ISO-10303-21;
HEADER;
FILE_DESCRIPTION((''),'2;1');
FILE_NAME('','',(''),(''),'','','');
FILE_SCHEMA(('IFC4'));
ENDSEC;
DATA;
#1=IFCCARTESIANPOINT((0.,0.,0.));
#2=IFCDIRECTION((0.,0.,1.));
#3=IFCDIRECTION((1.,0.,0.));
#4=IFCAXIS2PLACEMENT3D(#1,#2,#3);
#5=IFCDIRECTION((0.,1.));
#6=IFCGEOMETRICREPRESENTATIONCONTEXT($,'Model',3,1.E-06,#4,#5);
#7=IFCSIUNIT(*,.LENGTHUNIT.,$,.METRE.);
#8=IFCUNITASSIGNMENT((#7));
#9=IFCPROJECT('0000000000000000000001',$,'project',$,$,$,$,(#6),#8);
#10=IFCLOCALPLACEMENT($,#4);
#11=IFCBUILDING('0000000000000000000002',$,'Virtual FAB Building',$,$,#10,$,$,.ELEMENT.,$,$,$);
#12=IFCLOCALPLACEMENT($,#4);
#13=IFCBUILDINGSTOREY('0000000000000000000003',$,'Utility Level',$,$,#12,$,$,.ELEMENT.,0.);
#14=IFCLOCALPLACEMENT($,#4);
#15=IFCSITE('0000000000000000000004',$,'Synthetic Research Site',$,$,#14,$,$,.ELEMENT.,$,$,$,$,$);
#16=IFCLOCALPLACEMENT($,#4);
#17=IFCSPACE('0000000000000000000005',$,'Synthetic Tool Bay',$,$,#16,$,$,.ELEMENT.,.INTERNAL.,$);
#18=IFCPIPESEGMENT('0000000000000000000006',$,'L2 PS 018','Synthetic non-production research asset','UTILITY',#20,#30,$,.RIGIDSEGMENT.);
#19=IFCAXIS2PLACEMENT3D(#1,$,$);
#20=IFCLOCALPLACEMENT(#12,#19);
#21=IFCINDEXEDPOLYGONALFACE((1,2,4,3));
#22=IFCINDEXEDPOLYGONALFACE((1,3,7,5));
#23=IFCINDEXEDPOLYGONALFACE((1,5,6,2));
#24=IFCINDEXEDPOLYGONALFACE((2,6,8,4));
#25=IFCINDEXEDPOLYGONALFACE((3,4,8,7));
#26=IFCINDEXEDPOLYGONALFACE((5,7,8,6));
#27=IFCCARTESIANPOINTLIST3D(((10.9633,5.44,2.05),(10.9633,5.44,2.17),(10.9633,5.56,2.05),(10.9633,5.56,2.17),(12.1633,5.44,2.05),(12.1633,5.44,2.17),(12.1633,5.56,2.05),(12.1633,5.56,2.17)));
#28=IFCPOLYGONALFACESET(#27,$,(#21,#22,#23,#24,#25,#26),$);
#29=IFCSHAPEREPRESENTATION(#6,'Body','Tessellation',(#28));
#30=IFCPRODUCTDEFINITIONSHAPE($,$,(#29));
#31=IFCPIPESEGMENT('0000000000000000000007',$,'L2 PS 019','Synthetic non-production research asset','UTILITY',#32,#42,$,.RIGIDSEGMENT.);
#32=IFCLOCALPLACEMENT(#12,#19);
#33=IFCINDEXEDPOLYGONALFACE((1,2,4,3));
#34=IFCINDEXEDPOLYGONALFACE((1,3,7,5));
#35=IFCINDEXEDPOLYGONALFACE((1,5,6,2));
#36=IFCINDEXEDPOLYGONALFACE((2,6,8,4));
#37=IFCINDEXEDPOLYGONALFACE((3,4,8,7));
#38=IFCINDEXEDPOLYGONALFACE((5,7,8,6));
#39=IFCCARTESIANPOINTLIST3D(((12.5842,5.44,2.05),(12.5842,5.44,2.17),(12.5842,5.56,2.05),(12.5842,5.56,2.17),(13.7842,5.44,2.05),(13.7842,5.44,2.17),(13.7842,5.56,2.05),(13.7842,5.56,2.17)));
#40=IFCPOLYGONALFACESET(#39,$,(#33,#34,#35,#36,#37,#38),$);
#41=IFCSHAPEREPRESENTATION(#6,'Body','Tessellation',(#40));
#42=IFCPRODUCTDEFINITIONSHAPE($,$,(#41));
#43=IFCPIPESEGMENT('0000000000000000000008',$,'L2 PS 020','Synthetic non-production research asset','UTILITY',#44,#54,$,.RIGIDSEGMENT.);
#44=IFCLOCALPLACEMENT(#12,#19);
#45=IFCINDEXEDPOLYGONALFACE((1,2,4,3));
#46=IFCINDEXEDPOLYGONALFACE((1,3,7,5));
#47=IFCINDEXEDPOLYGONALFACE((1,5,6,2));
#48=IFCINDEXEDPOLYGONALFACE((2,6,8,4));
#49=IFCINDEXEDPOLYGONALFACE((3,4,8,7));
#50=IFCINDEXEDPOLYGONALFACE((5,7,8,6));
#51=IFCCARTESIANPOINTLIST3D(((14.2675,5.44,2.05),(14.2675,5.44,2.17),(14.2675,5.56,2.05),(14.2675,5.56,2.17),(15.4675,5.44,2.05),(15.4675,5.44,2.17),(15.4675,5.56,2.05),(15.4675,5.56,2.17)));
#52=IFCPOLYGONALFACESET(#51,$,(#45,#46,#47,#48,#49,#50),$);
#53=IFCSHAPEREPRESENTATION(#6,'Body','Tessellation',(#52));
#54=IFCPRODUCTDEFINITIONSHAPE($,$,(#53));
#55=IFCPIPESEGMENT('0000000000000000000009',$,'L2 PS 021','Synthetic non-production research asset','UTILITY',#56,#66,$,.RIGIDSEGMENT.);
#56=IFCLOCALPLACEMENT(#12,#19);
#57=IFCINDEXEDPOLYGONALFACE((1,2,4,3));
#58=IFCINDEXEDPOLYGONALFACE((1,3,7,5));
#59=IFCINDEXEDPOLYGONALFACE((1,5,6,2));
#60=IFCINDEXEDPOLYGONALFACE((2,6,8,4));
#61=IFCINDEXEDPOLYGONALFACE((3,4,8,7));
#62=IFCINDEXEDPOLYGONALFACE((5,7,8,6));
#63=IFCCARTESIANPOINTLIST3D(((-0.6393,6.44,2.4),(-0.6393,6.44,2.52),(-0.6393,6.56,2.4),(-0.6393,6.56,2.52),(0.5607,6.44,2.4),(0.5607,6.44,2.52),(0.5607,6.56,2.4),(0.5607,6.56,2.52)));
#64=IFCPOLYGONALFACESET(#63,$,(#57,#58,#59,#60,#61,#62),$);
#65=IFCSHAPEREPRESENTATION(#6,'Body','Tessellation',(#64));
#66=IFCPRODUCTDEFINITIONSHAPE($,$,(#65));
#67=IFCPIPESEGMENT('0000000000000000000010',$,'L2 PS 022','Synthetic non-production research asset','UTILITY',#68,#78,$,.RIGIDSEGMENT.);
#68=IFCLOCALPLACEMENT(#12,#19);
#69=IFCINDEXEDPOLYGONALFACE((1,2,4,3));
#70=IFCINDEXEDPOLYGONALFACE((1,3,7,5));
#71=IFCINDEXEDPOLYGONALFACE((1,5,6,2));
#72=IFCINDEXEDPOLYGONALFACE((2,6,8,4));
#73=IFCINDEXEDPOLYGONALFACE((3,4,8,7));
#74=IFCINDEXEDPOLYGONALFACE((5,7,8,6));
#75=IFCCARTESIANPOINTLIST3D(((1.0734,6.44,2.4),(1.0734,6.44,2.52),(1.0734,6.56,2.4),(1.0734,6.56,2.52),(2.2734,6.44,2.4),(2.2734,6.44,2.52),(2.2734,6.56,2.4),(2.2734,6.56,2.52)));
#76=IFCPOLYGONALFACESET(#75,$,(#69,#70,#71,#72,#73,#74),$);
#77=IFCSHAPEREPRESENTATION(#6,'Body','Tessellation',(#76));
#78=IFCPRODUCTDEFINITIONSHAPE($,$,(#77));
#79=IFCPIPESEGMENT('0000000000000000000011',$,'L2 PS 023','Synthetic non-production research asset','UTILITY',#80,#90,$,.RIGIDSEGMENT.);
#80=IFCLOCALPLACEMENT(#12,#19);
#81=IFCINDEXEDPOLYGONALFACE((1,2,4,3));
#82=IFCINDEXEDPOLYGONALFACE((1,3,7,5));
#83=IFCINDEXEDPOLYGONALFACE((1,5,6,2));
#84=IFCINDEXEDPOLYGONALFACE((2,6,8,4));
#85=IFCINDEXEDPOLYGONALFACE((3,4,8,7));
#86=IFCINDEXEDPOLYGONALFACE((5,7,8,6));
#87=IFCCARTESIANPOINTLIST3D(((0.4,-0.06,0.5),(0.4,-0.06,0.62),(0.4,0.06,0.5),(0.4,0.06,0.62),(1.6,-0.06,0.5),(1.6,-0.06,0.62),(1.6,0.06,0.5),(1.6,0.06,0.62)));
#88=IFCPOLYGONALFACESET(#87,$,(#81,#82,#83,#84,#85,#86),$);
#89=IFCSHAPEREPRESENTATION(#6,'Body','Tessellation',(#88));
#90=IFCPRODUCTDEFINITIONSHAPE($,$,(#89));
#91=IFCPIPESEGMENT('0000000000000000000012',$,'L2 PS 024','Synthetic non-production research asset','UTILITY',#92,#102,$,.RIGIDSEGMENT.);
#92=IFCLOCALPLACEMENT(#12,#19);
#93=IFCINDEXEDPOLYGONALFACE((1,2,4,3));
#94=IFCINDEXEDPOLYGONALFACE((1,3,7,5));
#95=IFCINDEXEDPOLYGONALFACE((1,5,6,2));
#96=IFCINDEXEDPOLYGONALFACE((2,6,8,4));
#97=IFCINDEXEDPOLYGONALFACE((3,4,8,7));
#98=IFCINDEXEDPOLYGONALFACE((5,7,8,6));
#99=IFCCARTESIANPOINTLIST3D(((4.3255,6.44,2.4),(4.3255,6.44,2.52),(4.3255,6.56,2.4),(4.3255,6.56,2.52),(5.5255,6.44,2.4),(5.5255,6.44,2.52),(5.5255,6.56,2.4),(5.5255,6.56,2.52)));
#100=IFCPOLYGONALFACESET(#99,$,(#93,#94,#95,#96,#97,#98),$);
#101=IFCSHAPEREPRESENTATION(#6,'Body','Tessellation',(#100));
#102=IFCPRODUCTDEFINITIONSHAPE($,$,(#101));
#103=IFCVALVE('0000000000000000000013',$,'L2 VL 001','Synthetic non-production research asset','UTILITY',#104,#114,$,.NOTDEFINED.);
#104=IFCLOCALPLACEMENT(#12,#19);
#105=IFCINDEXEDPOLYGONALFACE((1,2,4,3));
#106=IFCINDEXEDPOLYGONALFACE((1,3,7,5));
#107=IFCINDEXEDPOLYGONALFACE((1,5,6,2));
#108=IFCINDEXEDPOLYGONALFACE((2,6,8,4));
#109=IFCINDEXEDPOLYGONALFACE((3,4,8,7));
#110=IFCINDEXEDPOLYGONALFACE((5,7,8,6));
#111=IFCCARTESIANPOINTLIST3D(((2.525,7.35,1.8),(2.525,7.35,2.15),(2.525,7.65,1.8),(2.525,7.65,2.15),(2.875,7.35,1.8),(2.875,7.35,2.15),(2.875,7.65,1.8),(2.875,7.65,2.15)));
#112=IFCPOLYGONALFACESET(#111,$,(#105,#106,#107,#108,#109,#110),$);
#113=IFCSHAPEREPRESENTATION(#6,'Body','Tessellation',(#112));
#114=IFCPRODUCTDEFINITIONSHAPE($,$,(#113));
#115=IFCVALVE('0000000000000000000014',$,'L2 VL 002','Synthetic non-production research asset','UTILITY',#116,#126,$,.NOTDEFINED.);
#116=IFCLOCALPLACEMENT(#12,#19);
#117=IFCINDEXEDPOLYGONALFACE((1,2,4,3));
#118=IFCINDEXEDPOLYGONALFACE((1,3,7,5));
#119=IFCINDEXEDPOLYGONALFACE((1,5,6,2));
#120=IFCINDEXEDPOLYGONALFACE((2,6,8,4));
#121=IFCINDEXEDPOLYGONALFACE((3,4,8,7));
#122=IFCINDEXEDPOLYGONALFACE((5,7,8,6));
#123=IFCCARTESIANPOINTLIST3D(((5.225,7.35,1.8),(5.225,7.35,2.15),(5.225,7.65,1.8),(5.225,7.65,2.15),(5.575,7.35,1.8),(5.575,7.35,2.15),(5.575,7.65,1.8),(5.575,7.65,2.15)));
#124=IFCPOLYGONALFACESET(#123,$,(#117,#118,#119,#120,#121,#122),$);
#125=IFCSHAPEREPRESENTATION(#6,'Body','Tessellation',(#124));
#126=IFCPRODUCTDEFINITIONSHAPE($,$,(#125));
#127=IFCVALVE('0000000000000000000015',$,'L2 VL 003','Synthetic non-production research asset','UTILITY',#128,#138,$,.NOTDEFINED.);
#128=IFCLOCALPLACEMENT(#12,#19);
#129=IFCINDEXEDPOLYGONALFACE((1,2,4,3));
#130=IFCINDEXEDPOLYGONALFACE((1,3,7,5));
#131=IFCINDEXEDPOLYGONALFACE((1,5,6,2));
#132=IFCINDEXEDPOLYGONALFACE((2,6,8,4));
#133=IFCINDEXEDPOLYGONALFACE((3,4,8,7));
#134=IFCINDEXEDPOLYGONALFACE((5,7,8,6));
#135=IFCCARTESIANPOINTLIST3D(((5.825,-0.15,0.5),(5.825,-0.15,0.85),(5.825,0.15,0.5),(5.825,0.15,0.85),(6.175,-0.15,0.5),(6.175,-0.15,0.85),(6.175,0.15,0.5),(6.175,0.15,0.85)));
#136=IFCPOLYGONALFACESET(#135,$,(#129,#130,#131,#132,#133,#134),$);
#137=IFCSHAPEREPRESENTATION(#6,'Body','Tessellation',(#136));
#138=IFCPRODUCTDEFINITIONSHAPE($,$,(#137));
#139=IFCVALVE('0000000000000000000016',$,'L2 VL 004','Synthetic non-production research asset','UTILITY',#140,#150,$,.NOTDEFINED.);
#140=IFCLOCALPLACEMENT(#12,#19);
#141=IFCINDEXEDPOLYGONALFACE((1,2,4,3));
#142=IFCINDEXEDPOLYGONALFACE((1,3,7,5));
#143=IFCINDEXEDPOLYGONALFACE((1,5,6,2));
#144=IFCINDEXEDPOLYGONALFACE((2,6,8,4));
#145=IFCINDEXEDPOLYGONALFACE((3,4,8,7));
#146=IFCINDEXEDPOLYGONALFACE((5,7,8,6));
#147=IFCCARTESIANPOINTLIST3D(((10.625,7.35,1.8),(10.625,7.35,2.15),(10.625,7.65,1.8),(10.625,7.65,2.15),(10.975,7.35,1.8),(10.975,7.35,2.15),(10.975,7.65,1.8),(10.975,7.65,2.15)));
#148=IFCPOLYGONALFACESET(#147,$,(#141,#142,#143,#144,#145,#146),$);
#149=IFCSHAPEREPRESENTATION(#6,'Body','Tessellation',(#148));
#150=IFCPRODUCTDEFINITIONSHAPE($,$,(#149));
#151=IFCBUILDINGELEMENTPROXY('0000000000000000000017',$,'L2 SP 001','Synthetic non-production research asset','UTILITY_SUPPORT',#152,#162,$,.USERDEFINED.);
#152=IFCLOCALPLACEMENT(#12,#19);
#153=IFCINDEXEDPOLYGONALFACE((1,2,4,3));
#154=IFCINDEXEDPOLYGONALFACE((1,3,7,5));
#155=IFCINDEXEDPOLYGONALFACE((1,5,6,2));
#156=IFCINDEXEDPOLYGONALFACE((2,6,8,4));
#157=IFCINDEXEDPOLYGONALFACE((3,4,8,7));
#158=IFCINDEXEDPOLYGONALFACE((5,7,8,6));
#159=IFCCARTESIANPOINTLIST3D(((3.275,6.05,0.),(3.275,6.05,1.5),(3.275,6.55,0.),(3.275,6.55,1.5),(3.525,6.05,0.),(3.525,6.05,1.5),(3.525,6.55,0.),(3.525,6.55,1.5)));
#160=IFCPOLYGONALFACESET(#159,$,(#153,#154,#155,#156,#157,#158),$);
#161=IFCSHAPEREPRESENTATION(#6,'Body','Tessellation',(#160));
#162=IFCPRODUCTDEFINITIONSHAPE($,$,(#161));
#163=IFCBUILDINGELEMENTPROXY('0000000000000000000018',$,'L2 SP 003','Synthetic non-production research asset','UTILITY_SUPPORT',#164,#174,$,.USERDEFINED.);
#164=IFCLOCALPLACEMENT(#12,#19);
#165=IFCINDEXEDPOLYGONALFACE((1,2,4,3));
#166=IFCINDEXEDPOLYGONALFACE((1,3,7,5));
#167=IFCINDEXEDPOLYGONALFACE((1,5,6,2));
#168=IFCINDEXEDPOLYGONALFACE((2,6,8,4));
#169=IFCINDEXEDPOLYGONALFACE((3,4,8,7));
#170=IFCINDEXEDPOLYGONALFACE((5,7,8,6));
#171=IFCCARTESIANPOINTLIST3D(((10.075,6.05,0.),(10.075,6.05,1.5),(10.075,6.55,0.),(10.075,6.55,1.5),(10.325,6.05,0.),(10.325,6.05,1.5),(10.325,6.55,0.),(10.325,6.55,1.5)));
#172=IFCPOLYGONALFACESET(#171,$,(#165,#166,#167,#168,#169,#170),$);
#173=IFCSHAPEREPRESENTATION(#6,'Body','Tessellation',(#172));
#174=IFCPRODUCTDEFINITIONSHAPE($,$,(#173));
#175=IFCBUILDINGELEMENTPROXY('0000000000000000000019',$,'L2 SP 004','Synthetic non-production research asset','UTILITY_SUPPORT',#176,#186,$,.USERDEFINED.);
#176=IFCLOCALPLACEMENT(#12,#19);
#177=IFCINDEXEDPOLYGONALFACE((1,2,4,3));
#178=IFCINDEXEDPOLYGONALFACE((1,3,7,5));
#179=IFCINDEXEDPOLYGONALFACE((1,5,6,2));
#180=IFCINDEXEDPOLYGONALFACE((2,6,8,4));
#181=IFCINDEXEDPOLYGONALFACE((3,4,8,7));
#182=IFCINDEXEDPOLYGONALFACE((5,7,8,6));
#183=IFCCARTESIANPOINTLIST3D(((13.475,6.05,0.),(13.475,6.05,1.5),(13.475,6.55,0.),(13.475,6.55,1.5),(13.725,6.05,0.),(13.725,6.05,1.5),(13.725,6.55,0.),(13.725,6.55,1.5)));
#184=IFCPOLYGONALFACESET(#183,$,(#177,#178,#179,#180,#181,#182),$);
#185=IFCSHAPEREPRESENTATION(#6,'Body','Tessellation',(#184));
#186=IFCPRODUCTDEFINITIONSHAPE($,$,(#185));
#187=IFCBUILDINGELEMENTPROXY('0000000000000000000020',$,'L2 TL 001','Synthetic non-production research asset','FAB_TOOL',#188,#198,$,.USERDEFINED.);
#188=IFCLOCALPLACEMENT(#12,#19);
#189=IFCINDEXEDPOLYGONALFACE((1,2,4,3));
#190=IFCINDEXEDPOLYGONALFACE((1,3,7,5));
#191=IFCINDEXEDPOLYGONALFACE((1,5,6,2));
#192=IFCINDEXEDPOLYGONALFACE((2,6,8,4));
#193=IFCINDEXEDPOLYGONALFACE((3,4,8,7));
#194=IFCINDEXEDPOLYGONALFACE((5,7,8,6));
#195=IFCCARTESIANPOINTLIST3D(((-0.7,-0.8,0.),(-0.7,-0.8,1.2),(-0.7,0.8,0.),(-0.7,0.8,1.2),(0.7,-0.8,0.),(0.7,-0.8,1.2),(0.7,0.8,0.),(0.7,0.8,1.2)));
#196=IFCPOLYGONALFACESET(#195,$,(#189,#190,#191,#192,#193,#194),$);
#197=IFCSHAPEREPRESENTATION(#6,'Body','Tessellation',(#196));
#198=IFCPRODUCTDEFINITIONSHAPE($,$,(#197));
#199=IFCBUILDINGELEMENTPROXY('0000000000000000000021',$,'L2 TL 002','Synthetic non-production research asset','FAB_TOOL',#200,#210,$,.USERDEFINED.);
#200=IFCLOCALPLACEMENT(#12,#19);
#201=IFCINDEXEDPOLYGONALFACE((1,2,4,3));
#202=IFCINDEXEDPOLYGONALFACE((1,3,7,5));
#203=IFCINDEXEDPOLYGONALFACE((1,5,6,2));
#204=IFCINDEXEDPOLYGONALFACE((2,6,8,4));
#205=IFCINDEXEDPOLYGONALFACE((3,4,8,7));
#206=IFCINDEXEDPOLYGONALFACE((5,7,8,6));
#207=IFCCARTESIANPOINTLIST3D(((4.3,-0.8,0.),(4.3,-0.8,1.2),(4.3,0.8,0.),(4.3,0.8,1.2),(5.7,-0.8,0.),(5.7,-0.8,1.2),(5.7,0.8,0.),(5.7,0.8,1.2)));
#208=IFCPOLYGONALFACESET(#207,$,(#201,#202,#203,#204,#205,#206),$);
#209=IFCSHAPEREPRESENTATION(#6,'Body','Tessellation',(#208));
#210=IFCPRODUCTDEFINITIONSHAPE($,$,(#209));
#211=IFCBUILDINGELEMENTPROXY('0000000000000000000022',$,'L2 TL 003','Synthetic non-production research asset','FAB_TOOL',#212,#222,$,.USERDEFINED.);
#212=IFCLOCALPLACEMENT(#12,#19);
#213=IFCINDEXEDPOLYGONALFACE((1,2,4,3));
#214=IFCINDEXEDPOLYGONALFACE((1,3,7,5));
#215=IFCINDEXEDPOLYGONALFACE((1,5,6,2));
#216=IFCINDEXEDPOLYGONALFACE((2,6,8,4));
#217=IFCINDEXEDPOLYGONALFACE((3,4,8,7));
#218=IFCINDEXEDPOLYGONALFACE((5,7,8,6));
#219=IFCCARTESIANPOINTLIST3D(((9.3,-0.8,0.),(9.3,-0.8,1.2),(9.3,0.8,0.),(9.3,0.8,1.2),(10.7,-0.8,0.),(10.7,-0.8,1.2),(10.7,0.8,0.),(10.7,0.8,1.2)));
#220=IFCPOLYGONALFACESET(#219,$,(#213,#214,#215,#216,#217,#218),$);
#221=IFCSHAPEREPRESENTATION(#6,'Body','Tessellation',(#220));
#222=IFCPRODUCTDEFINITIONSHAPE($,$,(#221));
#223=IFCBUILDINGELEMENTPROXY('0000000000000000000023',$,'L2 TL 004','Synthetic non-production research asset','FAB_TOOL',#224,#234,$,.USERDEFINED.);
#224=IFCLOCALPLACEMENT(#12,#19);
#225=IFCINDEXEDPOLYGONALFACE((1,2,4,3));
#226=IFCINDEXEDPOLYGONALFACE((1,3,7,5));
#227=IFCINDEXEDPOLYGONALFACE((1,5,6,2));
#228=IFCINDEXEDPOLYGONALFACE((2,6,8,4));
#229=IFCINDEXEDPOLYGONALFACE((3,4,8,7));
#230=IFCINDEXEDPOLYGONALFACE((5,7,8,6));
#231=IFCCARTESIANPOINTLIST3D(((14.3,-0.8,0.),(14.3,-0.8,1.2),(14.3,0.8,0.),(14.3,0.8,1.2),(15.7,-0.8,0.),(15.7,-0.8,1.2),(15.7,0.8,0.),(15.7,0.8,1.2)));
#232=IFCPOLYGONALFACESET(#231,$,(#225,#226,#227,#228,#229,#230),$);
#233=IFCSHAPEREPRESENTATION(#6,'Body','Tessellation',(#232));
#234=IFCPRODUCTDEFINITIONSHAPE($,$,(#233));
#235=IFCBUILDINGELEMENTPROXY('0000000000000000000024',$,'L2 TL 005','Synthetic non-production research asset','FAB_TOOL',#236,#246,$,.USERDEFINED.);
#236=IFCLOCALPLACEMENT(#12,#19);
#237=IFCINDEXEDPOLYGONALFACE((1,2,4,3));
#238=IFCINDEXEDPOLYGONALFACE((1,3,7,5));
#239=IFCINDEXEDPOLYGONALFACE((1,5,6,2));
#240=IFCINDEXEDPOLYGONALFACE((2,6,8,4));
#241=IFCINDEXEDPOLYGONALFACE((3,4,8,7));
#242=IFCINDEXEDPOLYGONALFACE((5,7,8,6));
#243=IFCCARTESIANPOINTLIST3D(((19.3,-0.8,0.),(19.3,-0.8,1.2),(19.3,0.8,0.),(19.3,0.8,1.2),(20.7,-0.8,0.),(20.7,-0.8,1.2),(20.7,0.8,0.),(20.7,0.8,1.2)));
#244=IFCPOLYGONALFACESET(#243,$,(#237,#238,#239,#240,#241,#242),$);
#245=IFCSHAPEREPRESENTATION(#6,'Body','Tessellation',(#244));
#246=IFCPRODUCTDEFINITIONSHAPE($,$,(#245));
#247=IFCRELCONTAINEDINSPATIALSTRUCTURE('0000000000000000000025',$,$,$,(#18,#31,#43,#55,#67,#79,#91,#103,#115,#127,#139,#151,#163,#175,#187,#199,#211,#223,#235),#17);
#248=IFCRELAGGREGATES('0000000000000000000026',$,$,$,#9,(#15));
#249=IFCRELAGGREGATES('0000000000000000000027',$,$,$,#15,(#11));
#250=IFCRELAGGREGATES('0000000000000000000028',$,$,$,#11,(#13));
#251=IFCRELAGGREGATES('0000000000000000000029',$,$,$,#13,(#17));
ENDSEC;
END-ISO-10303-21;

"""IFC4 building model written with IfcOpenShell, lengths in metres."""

from ifc_helpers import new_model, si_unit, direction, frame, origin_with_axes, origin_2d_with_axis, place, context, project, spatial, rectangle, extrude, element, save


model = new_model("IFC4")

# Units and contexts
model_context = context("Model", 3, precision=1e-06, world=origin_with_axes(), true_north=direction((0.0, 1.0)))
ifc_project = project(units=[si_unit("LENGTHUNIT", "METRE")], contexts=[model_context])

# Site, building, storey, space
site_placement = place(None, origin_with_axes())
site = spatial("IfcSite", under=ifc_project, at=site_placement, Name="Synthetic Research Site", CompositionType="ELEMENT")
building_placement = place(None, origin_with_axes())
building = spatial("IfcBuilding", under=site, at=building_placement, Name="Virtual FAB Building", CompositionType="ELEMENT")
storey_placement = place(None, origin_with_axes())
storey = spatial("IfcBuildingStorey", under=building, at=storey_placement, Name="Utility Level", CompositionType="ELEMENT", Elevation=0.0)
space_placement = place(None, origin_with_axes())
space = spatial("IfcSpace", under=storey, at=space_placement, Name="Synthetic Tool Bay", CompositionType="ELEMENT", PredefinedType="INTERNAL")

# Pipe segments
for number, where, z_axis, x_axis, name in (
    (1, (11.5633, 5.5, 2.05), (0.0, 0.0, 1.0), (1.0, 0.0, 0.0), "L2 PS 018"),
    (2, (13.1842, 5.5, 2.05), (0.0, 0.0, 1.0), (1.0, 0.0, 0.0), "L2 PS 019"),
    (3, (14.8675, 5.5, 2.05), (0.0, 0.0, 1.0), (1.0, 0.0, 0.0), "L2 PS 020"),
    (4, (-0.0393, 6.5, 2.4), (0.0, 0.0, 1.0), (1.0, 0.0, 0.0), "L2 PS 021"),
    (5, (1.6734, 6.5, 2.4), (0.0, 0.0, 1.0), (1.0, 0.0, 0.0), "L2 PS 022"),
    (6, (1.0, 0.0, 0.5), (0.0, 0.0, 1.0), (1.0, 0.0, 0.0), "L2 PS 023"),
    (7, (4.9255, 6.5, 2.4), (0.0, 0.0, 1.0), (1.0, 0.0, 0.0), "L2 PS 024"),
):
    element("IfcPipeSegment", number, at=place(None, frame(where, z_axis=z_axis, x_axis=x_axis)), inside=space, Name=name, Description="Synthetic non-production research asset", ObjectType="UTILITY", PredefinedType="RIGIDSEGMENT", context=model_context, shape_type="SweptSolid", body=[
        extrude(rectangle(XDim=1.2, YDim=0.12, at=origin_2d_with_axis()), origin_with_axes(), (0.0, 0.0, 1.0), 0.12),
    ])

# Valves
for number, where, z_axis, x_axis, name in (
    (8, (2.7, 7.5, 1.8), (0.0, 0.0, 1.0), (1.0, 0.0, 0.0), "L2 VL 001"),
    (9, (5.4, 7.5, 1.8), (0.0, 0.0, 1.0), (1.0, 0.0, 0.0), "L2 VL 002"),
    (10, (6.0, 0.0, 0.5), (0.0, 0.0, 1.0), (1.0, 0.0, 0.0), "L2 VL 003"),
    (11, (10.8, 7.5, 1.8), (0.0, 0.0, 1.0), (1.0, 0.0, 0.0), "L2 VL 004"),
):
    element("IfcValve", number, at=place(None, frame(where, z_axis=z_axis, x_axis=x_axis)), inside=space, Name=name, Description="Synthetic non-production research asset", ObjectType="UTILITY", PredefinedType="NOTDEFINED", context=model_context, shape_type="SweptSolid", body=[
        extrude(rectangle(XDim=0.35, YDim=0.3, at=origin_2d_with_axis()), origin_with_axes(), (0.0, 0.0, 1.0), 0.35),
    ])

# Building element proxies
for number, where, z_axis, x_axis, name in (
    (12, (3.4, 6.3, 0.0), (0.0, 0.0, 1.0), (1.0, 0.0, 0.0), "L2 SP 001"),
    (13, (10.2, 6.3, 0.0), (0.0, 0.0, 1.0), (1.0, 0.0, 0.0), "L2 SP 003"),
    (14, (13.6, 6.3, 0.0), (0.0, 0.0, 1.0), (1.0, 0.0, 0.0), "L2 SP 004"),
):
    element("IfcBuildingElementProxy", number, at=place(None, frame(where, z_axis=z_axis, x_axis=x_axis)), inside=space, Name=name, Description="Synthetic non-production research asset", ObjectType="UTILITY_SUPPORT", PredefinedType="USERDEFINED", context=model_context, shape_type="SweptSolid", body=[
        extrude(rectangle(XDim=0.25, YDim=0.5, at=origin_2d_with_axis()), origin_with_axes(), (0.0, 0.0, 1.0), 1.5),
    ])
for number, where, z_axis, x_axis, name in (
    (15, (0.0, 0.0, 0.0), (0.0, 0.0, 1.0), (1.0, 0.0, 0.0), "L2 TL 001"),
    (16, (5.0, 0.0, 0.0), (0.0, 0.0, 1.0), (1.0, 0.0, 0.0), "L2 TL 002"),
    (17, (10.0, 0.0, 0.0), (0.0, 0.0, 1.0), (1.0, 0.0, 0.0), "L2 TL 003"),
    (18, (15.0, 0.0, 0.0), (0.0, 0.0, 1.0), (1.0, 0.0, 0.0), "L2 TL 004"),
    (19, (20.0, 0.0, 0.0), (0.0, 0.0, 1.0), (1.0, 0.0, 0.0), "L2 TL 005"),
):
    element("IfcBuildingElementProxy", number, at=place(None, frame(where, z_axis=z_axis, x_axis=x_axis)), inside=space, Name=name, Description="Synthetic non-production research asset", ObjectType="FAB_TOOL", PredefinedType="USERDEFINED", context=model_context, shape_type="SweptSolid", body=[
        extrude(rectangle(XDim=1.4, YDim=1.6, at=origin_2d_with_axis()), origin_with_axes(), (0.0, 0.0, 1.0), 1.2),
    ])

save(model, "model.ifc")
